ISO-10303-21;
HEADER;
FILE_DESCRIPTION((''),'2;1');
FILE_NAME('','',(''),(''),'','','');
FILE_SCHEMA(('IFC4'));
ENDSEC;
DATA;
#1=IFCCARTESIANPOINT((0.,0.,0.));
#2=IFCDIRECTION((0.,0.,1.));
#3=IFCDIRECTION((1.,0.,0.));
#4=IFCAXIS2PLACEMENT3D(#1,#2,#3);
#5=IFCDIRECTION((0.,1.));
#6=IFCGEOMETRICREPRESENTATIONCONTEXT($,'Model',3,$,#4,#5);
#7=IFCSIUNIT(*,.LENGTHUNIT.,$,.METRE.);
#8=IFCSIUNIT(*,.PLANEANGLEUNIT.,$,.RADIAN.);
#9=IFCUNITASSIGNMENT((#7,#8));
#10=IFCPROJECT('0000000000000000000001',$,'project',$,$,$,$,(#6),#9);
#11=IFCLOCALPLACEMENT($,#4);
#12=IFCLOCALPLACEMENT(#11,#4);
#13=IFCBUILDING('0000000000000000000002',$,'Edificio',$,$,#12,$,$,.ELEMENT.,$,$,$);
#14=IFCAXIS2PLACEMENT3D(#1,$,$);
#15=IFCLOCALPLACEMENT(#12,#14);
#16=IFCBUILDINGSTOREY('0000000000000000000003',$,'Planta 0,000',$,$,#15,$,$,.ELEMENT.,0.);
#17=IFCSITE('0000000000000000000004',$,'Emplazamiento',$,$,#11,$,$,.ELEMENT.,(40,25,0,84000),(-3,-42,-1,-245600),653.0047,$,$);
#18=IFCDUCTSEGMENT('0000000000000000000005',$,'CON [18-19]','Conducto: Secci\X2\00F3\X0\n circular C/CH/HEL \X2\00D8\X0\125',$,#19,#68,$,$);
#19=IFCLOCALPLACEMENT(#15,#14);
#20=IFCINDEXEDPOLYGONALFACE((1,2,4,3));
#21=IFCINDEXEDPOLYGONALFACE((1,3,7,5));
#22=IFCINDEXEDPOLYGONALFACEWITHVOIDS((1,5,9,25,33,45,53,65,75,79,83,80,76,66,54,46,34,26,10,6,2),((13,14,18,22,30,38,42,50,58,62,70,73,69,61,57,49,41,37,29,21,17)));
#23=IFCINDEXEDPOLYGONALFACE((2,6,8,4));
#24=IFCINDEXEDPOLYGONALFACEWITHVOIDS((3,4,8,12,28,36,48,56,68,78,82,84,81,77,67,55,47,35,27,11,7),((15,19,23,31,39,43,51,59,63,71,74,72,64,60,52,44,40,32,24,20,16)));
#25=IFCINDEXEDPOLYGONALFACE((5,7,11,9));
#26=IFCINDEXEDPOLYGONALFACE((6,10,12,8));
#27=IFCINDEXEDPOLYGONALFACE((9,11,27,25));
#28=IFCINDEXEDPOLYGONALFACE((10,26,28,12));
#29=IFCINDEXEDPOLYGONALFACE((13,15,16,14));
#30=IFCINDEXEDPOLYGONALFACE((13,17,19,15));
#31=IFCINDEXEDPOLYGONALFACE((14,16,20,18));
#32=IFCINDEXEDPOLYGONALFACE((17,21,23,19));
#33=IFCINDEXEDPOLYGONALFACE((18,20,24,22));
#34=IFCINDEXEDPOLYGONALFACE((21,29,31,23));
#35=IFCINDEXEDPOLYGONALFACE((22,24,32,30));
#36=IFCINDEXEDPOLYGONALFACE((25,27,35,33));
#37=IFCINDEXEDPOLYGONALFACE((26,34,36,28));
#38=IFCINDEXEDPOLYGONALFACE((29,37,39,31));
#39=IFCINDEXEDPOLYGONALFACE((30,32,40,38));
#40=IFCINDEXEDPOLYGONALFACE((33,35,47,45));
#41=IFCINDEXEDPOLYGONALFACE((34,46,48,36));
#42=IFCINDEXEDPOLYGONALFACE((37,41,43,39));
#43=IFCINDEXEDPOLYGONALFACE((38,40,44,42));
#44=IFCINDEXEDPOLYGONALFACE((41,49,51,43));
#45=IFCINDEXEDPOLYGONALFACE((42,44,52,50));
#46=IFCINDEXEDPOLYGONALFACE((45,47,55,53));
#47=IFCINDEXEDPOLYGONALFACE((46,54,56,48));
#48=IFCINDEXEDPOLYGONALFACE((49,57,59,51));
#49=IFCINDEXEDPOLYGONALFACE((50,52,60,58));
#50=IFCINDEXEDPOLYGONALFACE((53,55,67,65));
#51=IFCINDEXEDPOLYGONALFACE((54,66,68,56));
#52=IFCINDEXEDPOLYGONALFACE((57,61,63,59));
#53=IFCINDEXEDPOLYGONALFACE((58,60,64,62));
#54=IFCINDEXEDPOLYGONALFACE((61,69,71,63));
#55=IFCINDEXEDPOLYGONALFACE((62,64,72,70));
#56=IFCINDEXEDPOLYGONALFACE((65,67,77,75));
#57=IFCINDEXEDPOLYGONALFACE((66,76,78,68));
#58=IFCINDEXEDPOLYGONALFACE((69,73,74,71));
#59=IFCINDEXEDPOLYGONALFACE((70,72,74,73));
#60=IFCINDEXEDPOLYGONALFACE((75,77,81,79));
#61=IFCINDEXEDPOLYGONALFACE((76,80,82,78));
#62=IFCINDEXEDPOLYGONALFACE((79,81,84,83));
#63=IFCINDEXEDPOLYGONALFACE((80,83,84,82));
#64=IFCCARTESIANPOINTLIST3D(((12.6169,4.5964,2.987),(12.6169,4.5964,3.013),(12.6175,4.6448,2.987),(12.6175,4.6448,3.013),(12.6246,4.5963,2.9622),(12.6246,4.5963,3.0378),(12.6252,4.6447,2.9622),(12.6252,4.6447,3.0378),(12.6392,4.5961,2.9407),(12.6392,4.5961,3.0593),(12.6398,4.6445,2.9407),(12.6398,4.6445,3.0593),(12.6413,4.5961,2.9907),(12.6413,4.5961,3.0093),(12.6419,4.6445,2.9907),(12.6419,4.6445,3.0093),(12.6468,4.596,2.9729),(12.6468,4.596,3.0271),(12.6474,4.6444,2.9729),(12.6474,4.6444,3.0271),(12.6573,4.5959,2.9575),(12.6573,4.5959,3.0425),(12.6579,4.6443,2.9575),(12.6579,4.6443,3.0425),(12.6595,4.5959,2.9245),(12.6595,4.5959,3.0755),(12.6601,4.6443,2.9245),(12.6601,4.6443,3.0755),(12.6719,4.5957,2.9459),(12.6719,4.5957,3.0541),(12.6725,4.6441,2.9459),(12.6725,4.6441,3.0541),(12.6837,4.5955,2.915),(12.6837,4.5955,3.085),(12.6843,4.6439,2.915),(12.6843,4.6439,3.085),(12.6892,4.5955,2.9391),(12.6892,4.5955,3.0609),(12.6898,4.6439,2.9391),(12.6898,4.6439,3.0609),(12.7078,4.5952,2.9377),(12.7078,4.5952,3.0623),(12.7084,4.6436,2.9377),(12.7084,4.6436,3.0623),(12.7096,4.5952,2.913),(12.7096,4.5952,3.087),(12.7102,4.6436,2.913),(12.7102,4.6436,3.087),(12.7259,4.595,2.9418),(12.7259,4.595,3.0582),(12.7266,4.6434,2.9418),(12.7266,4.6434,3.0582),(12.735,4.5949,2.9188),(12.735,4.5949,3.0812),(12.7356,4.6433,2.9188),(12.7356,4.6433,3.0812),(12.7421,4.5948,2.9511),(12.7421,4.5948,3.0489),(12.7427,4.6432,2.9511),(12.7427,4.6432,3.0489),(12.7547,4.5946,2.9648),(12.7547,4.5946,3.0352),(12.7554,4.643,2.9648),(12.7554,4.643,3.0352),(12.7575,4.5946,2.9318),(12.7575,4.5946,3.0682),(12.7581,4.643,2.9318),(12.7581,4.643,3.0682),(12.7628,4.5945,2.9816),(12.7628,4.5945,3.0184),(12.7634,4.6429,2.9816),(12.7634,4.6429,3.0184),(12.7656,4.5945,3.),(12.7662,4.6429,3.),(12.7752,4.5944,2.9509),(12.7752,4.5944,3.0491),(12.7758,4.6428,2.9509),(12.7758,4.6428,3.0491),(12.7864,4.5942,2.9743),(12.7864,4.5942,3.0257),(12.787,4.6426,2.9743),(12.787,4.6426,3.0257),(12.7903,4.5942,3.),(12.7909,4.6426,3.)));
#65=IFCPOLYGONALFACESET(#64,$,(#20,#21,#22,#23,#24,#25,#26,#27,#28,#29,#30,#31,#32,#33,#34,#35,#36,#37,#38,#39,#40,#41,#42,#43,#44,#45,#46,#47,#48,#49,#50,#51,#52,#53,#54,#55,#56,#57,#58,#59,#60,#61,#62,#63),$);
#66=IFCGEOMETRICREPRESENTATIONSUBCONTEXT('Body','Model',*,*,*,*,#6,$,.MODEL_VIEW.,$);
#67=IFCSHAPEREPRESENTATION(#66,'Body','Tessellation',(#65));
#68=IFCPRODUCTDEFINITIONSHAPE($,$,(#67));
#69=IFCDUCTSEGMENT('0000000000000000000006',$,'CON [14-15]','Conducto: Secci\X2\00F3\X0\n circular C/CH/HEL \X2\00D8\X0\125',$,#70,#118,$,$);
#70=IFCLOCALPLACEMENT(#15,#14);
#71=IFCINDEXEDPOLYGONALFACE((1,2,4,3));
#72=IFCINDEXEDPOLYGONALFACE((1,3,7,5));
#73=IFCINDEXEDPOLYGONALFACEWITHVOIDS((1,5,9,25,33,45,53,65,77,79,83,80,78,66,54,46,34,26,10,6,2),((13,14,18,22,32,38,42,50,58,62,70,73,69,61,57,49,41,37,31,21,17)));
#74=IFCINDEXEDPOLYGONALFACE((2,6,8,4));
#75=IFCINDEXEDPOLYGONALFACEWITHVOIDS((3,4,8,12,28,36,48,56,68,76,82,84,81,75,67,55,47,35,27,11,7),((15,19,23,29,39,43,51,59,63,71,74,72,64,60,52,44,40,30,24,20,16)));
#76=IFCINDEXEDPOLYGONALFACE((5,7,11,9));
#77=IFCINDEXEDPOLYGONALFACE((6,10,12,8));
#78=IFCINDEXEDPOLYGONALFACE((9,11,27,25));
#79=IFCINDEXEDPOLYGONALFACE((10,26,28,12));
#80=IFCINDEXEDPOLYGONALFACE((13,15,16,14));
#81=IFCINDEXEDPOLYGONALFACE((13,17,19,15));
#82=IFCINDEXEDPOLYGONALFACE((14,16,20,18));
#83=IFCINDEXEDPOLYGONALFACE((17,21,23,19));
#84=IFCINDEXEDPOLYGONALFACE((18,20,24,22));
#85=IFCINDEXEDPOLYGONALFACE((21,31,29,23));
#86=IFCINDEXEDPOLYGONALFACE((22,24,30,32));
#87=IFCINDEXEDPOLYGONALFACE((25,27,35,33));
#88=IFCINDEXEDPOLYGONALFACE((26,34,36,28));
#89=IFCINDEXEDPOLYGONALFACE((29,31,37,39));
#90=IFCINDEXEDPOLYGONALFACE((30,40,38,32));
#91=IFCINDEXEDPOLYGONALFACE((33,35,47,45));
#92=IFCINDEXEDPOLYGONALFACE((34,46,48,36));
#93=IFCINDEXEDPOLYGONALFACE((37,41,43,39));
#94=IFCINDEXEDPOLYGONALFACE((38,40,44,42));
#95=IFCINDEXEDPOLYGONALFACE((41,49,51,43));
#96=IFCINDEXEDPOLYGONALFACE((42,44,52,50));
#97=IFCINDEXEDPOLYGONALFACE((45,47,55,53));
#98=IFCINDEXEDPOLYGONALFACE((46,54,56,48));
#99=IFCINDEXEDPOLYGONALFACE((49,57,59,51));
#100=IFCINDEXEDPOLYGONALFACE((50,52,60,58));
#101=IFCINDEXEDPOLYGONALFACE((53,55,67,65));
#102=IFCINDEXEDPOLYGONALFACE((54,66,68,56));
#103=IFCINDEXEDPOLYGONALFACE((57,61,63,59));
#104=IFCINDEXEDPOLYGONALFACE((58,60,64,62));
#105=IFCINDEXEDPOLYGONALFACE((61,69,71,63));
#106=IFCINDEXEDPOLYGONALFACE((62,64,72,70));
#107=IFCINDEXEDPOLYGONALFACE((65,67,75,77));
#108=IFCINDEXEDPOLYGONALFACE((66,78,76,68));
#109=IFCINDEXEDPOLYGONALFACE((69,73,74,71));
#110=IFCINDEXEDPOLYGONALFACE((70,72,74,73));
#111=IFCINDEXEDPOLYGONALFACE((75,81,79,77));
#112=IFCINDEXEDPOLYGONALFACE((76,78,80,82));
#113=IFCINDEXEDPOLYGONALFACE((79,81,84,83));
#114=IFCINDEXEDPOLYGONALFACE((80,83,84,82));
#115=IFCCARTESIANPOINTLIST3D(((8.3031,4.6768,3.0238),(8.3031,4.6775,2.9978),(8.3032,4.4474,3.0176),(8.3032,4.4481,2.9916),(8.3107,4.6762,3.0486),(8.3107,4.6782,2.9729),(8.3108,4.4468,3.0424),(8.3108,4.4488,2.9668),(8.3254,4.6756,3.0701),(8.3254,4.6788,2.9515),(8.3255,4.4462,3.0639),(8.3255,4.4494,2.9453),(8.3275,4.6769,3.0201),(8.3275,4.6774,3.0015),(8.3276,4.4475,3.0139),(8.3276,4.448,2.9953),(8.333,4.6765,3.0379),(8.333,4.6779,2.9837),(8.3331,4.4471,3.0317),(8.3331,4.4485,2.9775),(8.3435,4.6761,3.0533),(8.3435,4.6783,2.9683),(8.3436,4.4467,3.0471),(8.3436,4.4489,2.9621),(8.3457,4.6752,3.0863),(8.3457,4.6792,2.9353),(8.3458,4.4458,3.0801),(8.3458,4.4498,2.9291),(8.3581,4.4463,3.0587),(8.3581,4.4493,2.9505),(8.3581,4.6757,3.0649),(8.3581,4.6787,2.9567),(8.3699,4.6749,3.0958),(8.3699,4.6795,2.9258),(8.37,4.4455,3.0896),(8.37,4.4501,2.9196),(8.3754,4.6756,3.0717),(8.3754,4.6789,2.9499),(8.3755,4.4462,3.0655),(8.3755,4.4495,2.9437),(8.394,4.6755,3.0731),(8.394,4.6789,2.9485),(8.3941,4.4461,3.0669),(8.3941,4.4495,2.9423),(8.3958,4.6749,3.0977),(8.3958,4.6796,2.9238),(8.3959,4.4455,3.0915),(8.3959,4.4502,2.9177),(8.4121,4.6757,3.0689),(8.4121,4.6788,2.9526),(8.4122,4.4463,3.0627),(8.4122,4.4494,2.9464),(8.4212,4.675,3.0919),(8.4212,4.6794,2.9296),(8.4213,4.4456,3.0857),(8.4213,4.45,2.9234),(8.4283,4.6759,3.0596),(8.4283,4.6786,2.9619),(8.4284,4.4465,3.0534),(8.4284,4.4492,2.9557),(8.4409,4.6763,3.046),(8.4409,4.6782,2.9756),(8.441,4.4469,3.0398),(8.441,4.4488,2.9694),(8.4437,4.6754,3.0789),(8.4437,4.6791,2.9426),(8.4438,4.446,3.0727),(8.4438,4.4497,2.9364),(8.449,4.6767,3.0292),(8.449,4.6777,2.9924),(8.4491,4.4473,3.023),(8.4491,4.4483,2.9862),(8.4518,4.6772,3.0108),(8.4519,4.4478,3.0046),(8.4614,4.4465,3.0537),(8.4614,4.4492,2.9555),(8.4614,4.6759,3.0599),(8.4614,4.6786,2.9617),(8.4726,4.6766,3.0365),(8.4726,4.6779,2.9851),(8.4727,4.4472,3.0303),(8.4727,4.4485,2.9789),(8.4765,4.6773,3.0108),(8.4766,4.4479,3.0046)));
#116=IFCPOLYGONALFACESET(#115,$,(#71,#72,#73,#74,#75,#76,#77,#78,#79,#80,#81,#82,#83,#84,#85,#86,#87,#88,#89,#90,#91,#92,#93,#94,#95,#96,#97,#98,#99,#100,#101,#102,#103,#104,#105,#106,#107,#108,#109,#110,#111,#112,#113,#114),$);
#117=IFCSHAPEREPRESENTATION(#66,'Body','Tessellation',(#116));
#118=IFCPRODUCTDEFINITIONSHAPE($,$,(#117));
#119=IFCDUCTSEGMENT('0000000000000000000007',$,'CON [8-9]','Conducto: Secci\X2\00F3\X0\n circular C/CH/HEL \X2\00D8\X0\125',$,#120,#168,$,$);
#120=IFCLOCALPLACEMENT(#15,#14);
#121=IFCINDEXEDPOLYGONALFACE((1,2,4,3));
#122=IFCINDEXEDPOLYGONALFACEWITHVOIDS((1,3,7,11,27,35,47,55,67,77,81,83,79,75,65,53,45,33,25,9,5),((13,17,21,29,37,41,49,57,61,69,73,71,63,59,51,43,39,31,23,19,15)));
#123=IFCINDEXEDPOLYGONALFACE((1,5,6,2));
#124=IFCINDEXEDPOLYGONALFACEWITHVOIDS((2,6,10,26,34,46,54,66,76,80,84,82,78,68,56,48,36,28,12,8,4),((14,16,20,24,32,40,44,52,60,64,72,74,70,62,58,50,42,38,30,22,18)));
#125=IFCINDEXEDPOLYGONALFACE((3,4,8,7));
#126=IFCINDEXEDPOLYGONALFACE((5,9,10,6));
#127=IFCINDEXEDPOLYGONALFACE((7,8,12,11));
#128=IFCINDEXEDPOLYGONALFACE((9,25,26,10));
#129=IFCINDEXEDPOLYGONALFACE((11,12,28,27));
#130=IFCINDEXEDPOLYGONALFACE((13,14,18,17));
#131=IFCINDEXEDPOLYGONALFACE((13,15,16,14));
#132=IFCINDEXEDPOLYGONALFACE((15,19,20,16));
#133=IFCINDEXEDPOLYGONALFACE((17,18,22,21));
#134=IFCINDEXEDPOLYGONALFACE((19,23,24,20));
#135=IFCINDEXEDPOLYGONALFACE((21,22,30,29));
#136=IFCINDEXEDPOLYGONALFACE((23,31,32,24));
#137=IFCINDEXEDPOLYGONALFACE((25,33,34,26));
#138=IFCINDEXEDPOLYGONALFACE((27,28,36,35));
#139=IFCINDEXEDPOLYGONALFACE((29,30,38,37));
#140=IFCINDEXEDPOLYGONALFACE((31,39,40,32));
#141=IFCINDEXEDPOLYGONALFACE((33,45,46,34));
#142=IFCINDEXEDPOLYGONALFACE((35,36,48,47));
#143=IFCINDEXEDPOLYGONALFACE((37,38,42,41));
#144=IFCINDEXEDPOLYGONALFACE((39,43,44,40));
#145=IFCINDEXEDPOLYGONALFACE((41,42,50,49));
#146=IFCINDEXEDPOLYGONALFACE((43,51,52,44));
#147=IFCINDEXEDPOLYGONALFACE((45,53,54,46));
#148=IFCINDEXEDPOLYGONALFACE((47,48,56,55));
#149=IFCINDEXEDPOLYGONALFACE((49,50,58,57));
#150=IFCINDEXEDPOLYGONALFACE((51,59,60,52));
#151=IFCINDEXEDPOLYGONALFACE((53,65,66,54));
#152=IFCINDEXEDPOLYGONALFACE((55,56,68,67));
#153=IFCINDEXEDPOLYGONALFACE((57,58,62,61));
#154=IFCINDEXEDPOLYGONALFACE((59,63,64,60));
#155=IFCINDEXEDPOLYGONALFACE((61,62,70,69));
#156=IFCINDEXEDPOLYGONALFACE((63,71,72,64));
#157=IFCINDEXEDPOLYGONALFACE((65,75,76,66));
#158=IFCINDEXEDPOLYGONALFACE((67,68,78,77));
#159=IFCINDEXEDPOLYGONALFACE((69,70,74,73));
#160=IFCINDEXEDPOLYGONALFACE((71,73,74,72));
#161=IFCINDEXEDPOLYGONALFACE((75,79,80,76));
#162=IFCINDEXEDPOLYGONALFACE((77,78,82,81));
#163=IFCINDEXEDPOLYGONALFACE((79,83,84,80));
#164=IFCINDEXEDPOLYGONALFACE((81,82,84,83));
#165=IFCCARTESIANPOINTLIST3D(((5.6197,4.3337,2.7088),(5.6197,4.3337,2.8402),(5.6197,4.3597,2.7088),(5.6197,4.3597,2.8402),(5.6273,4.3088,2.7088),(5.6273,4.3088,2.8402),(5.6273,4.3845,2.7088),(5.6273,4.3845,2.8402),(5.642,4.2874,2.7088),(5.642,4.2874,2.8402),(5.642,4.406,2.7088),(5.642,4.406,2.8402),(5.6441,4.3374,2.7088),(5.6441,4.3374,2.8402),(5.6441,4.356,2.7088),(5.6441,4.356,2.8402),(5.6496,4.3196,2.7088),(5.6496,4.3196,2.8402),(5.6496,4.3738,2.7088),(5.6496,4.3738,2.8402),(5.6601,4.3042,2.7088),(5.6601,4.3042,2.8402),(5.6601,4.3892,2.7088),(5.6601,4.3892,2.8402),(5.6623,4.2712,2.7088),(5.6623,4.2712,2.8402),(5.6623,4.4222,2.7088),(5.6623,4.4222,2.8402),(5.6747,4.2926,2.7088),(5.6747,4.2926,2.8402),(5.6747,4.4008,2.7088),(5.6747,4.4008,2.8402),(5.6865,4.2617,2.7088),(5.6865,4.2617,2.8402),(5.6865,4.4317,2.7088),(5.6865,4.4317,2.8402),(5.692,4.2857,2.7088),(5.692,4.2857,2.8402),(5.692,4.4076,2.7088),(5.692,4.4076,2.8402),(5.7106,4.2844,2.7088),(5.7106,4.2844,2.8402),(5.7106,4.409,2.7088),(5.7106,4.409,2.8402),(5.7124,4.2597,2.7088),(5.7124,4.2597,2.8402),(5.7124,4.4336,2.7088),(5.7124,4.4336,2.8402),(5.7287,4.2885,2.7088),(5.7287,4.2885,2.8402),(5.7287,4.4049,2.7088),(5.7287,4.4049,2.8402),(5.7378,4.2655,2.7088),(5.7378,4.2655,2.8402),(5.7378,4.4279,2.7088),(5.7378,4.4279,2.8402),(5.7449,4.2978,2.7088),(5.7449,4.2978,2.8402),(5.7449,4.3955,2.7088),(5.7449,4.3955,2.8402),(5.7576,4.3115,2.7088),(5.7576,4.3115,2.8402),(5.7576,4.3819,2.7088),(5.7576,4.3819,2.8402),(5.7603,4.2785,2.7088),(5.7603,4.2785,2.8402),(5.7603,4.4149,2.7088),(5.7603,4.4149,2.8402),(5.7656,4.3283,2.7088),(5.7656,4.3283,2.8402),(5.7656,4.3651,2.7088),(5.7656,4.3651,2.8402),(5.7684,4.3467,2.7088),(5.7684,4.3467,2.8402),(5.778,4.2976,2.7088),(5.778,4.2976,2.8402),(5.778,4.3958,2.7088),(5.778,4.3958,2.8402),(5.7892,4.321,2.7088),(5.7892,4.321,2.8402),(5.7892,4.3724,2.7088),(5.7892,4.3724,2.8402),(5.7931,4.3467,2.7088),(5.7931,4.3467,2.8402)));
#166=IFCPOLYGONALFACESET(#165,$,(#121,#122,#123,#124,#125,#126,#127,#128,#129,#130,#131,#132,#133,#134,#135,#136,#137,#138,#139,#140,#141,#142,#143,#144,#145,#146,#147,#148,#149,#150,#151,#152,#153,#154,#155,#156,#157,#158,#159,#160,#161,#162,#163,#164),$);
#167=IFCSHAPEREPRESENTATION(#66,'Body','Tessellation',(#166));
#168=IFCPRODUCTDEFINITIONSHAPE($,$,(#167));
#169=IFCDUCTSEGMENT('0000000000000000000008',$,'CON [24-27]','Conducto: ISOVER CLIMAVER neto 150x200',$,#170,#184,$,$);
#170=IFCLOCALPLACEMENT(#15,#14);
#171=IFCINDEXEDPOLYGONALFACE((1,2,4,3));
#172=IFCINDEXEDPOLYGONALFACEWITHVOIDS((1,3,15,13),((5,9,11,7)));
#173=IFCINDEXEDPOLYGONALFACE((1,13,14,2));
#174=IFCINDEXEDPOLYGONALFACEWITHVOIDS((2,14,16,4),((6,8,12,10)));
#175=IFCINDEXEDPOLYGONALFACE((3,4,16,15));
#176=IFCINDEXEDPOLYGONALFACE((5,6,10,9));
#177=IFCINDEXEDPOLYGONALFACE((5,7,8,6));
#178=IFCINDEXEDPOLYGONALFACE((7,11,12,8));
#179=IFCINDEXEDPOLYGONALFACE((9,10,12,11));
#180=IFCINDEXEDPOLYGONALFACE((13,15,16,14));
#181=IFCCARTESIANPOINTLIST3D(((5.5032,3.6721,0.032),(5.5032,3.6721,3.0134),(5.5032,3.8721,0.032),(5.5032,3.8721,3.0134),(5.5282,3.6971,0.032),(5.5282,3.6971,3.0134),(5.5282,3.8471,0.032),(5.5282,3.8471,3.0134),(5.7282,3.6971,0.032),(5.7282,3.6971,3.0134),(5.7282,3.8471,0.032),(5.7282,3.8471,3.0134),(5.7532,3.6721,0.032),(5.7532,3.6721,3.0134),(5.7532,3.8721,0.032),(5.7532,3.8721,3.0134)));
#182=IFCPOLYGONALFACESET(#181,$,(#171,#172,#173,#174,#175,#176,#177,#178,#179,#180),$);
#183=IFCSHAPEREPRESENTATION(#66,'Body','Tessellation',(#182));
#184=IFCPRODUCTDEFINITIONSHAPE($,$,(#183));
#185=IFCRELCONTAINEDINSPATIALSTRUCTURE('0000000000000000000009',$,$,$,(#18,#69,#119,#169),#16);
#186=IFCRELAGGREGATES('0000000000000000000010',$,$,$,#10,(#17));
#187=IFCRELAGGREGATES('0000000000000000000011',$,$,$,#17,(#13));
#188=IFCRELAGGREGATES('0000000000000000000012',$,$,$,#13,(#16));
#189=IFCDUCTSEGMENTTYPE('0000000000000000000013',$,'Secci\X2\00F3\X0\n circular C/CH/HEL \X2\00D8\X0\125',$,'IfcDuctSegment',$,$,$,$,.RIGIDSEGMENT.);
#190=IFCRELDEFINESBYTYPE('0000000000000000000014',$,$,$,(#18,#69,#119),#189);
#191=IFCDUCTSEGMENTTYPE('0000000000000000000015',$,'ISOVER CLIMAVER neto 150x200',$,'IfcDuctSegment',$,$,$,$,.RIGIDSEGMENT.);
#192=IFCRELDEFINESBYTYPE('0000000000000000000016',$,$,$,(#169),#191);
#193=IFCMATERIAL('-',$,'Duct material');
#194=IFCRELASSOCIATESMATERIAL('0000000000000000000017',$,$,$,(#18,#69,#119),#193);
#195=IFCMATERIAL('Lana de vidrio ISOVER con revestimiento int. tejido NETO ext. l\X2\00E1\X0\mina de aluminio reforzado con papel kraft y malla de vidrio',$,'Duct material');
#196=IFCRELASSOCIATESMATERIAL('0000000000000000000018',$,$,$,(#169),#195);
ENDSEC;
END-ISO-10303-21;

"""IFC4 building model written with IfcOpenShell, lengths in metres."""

from ifc_helpers import new_model, si_unit, direction, frame, origin, origin_with_axes, origin_2d_with_axis, place, context, subcontext, project, spatial, hollow_rectangle, hollow_circle, extrude, material, type_object, element, save


model = new_model("IFC4")

# Units and contexts
model_context = context("Model", 3, world=origin_with_axes(), true_north=direction((0.0, 1.0)))
body_context = subcontext(model_context, "Body", "Model", "MODEL_VIEW")
ifc_project = project(units=[si_unit("LENGTHUNIT", "METRE"), si_unit("PLANEANGLEUNIT", "RADIAN")], contexts=[model_context])

# Site, building, storey
site_placement = place(None, origin_with_axes())
site = spatial("IfcSite", under=ifc_project, at=site_placement, Name="Emplazamiento", CompositionType="ELEMENT", RefLatitude=(40, 25, 0, 84000), RefLongitude=(-3, -42, -1, -245600), RefElevation=653.0047)
building_placement = place(site_placement, origin_with_axes())
building = spatial("IfcBuilding", under=site, at=building_placement, Name="Edificio", CompositionType="ELEMENT")
storey_placement = place(building_placement, origin())
storey = spatial("IfcBuildingStorey", under=building, at=storey_placement, Name="Planta 0,000", CompositionType="ELEMENT", Elevation=0.0)

# Shared definitions
ifc_material_1 = material(Name="-", Category="Duct material")

# Duct segments
ifc_material_2 = material(Name="Lana de vidrio ISOVER con revestimiento int. tejido NETO ext. lámina de aluminio reforzado con papel kraft y malla de vidrio", Category="Duct material")
duct_segment_type_1 = type_object("IfcDuctSegmentType", Name="Sección circular C/CH/HEL Ø125", ApplicableOccurrence="IfcDuctSegment", PredefinedType="RIGIDSEGMENT")
duct_segment_1_placement = place(storey_placement, origin_with_axes())
element("IfcDuctSegment", 1, at=duct_segment_1_placement, inside=storey, type_object=duct_segment_type_1, material=ifc_material_1, Name="CON [18-19]", Description="Conducto: Sección circular C/CH/HEL Ø125", context=body_context, shape_type="SweptSolid", body=[
    extrude(hollow_circle(Radius=0.0872, WallThickness=0.0247, at=origin_2d_with_axis()), frame((12.7037, 4.6437, 3.0), z_axis=(-0.01268, -0.99992, 0.0), x_axis=(0.99992, -0.01268, 0.0)), (0.0, 0.0, 1.0), 0.0484),
])
duct_segment_2_placement = place(storey_placement, origin_with_axes())
element("IfcDuctSegment", 2, at=duct_segment_2_placement, inside=storey, type_object=duct_segment_type_1, material=ifc_material_1, Name="CON [14-15]", Description="Conducto: Sección circular C/CH/HEL Ø125", context=body_context, shape_type="SweptSolid", body=[
    extrude(hollow_circle(Radius=0.0872, WallThickness=0.0247, at=origin_2d_with_axis()), frame((8.3893, 4.6772, 3.0108), z_axis=(0.000384, -0.999636, -0.026971), x_axis=(1.0, 0.000384, 0.0)), (0.0, 0.0, 1.0), 0.2295),
])
duct_segment_3_placement = place(storey_placement, origin_with_axes())
element("IfcDuctSegment", 3, at=duct_segment_3_placement, inside=storey, type_object=duct_segment_type_1, material=ifc_material_1, Name="CON [8-9]", Description="Conducto: Sección circular C/CH/HEL Ø125", context=body_context, shape_type="SweptSolid", body=[
    extrude(hollow_circle(Radius=0.0872, WallThickness=0.0247, at=origin_2d_with_axis()), frame((5.7059, 4.3467, 2.8402), z_axis=(0.0, 0.0, -1.0), x_axis=(1.0, -0.000024, 0.0)), (0.0, 0.0, 1.0), 0.1314),
])

# Duct segment
duct_segment_type_2 = type_object("IfcDuctSegmentType", Name="ISOVER CLIMAVER neto 150x200", ApplicableOccurrence="IfcDuctSegment", PredefinedType="RIGIDSEGMENT")
duct_segment_4_placement = place(storey_placement, origin_with_axes())
element("IfcDuctSegment", 4, at=duct_segment_4_placement, inside=storey, type_object=duct_segment_type_2, material=ifc_material_2, Name="CON [24-27]", Description="Conducto: ISOVER CLIMAVER neto 150x200", context=body_context, shape_type="SweptSolid", body=[
    extrude(hollow_rectangle(XDim=0.2, YDim=0.25, WallThickness=0.025, at=origin_2d_with_axis()), frame((5.6282, 3.7721, 3.0134), z_axis=(0.0, 0.0, -1.0), x_axis=(0.0, -1.0, 0.0)), (0.0, 0.0, 1.0), 2.9814),
])

save(model, "model.ifc")
